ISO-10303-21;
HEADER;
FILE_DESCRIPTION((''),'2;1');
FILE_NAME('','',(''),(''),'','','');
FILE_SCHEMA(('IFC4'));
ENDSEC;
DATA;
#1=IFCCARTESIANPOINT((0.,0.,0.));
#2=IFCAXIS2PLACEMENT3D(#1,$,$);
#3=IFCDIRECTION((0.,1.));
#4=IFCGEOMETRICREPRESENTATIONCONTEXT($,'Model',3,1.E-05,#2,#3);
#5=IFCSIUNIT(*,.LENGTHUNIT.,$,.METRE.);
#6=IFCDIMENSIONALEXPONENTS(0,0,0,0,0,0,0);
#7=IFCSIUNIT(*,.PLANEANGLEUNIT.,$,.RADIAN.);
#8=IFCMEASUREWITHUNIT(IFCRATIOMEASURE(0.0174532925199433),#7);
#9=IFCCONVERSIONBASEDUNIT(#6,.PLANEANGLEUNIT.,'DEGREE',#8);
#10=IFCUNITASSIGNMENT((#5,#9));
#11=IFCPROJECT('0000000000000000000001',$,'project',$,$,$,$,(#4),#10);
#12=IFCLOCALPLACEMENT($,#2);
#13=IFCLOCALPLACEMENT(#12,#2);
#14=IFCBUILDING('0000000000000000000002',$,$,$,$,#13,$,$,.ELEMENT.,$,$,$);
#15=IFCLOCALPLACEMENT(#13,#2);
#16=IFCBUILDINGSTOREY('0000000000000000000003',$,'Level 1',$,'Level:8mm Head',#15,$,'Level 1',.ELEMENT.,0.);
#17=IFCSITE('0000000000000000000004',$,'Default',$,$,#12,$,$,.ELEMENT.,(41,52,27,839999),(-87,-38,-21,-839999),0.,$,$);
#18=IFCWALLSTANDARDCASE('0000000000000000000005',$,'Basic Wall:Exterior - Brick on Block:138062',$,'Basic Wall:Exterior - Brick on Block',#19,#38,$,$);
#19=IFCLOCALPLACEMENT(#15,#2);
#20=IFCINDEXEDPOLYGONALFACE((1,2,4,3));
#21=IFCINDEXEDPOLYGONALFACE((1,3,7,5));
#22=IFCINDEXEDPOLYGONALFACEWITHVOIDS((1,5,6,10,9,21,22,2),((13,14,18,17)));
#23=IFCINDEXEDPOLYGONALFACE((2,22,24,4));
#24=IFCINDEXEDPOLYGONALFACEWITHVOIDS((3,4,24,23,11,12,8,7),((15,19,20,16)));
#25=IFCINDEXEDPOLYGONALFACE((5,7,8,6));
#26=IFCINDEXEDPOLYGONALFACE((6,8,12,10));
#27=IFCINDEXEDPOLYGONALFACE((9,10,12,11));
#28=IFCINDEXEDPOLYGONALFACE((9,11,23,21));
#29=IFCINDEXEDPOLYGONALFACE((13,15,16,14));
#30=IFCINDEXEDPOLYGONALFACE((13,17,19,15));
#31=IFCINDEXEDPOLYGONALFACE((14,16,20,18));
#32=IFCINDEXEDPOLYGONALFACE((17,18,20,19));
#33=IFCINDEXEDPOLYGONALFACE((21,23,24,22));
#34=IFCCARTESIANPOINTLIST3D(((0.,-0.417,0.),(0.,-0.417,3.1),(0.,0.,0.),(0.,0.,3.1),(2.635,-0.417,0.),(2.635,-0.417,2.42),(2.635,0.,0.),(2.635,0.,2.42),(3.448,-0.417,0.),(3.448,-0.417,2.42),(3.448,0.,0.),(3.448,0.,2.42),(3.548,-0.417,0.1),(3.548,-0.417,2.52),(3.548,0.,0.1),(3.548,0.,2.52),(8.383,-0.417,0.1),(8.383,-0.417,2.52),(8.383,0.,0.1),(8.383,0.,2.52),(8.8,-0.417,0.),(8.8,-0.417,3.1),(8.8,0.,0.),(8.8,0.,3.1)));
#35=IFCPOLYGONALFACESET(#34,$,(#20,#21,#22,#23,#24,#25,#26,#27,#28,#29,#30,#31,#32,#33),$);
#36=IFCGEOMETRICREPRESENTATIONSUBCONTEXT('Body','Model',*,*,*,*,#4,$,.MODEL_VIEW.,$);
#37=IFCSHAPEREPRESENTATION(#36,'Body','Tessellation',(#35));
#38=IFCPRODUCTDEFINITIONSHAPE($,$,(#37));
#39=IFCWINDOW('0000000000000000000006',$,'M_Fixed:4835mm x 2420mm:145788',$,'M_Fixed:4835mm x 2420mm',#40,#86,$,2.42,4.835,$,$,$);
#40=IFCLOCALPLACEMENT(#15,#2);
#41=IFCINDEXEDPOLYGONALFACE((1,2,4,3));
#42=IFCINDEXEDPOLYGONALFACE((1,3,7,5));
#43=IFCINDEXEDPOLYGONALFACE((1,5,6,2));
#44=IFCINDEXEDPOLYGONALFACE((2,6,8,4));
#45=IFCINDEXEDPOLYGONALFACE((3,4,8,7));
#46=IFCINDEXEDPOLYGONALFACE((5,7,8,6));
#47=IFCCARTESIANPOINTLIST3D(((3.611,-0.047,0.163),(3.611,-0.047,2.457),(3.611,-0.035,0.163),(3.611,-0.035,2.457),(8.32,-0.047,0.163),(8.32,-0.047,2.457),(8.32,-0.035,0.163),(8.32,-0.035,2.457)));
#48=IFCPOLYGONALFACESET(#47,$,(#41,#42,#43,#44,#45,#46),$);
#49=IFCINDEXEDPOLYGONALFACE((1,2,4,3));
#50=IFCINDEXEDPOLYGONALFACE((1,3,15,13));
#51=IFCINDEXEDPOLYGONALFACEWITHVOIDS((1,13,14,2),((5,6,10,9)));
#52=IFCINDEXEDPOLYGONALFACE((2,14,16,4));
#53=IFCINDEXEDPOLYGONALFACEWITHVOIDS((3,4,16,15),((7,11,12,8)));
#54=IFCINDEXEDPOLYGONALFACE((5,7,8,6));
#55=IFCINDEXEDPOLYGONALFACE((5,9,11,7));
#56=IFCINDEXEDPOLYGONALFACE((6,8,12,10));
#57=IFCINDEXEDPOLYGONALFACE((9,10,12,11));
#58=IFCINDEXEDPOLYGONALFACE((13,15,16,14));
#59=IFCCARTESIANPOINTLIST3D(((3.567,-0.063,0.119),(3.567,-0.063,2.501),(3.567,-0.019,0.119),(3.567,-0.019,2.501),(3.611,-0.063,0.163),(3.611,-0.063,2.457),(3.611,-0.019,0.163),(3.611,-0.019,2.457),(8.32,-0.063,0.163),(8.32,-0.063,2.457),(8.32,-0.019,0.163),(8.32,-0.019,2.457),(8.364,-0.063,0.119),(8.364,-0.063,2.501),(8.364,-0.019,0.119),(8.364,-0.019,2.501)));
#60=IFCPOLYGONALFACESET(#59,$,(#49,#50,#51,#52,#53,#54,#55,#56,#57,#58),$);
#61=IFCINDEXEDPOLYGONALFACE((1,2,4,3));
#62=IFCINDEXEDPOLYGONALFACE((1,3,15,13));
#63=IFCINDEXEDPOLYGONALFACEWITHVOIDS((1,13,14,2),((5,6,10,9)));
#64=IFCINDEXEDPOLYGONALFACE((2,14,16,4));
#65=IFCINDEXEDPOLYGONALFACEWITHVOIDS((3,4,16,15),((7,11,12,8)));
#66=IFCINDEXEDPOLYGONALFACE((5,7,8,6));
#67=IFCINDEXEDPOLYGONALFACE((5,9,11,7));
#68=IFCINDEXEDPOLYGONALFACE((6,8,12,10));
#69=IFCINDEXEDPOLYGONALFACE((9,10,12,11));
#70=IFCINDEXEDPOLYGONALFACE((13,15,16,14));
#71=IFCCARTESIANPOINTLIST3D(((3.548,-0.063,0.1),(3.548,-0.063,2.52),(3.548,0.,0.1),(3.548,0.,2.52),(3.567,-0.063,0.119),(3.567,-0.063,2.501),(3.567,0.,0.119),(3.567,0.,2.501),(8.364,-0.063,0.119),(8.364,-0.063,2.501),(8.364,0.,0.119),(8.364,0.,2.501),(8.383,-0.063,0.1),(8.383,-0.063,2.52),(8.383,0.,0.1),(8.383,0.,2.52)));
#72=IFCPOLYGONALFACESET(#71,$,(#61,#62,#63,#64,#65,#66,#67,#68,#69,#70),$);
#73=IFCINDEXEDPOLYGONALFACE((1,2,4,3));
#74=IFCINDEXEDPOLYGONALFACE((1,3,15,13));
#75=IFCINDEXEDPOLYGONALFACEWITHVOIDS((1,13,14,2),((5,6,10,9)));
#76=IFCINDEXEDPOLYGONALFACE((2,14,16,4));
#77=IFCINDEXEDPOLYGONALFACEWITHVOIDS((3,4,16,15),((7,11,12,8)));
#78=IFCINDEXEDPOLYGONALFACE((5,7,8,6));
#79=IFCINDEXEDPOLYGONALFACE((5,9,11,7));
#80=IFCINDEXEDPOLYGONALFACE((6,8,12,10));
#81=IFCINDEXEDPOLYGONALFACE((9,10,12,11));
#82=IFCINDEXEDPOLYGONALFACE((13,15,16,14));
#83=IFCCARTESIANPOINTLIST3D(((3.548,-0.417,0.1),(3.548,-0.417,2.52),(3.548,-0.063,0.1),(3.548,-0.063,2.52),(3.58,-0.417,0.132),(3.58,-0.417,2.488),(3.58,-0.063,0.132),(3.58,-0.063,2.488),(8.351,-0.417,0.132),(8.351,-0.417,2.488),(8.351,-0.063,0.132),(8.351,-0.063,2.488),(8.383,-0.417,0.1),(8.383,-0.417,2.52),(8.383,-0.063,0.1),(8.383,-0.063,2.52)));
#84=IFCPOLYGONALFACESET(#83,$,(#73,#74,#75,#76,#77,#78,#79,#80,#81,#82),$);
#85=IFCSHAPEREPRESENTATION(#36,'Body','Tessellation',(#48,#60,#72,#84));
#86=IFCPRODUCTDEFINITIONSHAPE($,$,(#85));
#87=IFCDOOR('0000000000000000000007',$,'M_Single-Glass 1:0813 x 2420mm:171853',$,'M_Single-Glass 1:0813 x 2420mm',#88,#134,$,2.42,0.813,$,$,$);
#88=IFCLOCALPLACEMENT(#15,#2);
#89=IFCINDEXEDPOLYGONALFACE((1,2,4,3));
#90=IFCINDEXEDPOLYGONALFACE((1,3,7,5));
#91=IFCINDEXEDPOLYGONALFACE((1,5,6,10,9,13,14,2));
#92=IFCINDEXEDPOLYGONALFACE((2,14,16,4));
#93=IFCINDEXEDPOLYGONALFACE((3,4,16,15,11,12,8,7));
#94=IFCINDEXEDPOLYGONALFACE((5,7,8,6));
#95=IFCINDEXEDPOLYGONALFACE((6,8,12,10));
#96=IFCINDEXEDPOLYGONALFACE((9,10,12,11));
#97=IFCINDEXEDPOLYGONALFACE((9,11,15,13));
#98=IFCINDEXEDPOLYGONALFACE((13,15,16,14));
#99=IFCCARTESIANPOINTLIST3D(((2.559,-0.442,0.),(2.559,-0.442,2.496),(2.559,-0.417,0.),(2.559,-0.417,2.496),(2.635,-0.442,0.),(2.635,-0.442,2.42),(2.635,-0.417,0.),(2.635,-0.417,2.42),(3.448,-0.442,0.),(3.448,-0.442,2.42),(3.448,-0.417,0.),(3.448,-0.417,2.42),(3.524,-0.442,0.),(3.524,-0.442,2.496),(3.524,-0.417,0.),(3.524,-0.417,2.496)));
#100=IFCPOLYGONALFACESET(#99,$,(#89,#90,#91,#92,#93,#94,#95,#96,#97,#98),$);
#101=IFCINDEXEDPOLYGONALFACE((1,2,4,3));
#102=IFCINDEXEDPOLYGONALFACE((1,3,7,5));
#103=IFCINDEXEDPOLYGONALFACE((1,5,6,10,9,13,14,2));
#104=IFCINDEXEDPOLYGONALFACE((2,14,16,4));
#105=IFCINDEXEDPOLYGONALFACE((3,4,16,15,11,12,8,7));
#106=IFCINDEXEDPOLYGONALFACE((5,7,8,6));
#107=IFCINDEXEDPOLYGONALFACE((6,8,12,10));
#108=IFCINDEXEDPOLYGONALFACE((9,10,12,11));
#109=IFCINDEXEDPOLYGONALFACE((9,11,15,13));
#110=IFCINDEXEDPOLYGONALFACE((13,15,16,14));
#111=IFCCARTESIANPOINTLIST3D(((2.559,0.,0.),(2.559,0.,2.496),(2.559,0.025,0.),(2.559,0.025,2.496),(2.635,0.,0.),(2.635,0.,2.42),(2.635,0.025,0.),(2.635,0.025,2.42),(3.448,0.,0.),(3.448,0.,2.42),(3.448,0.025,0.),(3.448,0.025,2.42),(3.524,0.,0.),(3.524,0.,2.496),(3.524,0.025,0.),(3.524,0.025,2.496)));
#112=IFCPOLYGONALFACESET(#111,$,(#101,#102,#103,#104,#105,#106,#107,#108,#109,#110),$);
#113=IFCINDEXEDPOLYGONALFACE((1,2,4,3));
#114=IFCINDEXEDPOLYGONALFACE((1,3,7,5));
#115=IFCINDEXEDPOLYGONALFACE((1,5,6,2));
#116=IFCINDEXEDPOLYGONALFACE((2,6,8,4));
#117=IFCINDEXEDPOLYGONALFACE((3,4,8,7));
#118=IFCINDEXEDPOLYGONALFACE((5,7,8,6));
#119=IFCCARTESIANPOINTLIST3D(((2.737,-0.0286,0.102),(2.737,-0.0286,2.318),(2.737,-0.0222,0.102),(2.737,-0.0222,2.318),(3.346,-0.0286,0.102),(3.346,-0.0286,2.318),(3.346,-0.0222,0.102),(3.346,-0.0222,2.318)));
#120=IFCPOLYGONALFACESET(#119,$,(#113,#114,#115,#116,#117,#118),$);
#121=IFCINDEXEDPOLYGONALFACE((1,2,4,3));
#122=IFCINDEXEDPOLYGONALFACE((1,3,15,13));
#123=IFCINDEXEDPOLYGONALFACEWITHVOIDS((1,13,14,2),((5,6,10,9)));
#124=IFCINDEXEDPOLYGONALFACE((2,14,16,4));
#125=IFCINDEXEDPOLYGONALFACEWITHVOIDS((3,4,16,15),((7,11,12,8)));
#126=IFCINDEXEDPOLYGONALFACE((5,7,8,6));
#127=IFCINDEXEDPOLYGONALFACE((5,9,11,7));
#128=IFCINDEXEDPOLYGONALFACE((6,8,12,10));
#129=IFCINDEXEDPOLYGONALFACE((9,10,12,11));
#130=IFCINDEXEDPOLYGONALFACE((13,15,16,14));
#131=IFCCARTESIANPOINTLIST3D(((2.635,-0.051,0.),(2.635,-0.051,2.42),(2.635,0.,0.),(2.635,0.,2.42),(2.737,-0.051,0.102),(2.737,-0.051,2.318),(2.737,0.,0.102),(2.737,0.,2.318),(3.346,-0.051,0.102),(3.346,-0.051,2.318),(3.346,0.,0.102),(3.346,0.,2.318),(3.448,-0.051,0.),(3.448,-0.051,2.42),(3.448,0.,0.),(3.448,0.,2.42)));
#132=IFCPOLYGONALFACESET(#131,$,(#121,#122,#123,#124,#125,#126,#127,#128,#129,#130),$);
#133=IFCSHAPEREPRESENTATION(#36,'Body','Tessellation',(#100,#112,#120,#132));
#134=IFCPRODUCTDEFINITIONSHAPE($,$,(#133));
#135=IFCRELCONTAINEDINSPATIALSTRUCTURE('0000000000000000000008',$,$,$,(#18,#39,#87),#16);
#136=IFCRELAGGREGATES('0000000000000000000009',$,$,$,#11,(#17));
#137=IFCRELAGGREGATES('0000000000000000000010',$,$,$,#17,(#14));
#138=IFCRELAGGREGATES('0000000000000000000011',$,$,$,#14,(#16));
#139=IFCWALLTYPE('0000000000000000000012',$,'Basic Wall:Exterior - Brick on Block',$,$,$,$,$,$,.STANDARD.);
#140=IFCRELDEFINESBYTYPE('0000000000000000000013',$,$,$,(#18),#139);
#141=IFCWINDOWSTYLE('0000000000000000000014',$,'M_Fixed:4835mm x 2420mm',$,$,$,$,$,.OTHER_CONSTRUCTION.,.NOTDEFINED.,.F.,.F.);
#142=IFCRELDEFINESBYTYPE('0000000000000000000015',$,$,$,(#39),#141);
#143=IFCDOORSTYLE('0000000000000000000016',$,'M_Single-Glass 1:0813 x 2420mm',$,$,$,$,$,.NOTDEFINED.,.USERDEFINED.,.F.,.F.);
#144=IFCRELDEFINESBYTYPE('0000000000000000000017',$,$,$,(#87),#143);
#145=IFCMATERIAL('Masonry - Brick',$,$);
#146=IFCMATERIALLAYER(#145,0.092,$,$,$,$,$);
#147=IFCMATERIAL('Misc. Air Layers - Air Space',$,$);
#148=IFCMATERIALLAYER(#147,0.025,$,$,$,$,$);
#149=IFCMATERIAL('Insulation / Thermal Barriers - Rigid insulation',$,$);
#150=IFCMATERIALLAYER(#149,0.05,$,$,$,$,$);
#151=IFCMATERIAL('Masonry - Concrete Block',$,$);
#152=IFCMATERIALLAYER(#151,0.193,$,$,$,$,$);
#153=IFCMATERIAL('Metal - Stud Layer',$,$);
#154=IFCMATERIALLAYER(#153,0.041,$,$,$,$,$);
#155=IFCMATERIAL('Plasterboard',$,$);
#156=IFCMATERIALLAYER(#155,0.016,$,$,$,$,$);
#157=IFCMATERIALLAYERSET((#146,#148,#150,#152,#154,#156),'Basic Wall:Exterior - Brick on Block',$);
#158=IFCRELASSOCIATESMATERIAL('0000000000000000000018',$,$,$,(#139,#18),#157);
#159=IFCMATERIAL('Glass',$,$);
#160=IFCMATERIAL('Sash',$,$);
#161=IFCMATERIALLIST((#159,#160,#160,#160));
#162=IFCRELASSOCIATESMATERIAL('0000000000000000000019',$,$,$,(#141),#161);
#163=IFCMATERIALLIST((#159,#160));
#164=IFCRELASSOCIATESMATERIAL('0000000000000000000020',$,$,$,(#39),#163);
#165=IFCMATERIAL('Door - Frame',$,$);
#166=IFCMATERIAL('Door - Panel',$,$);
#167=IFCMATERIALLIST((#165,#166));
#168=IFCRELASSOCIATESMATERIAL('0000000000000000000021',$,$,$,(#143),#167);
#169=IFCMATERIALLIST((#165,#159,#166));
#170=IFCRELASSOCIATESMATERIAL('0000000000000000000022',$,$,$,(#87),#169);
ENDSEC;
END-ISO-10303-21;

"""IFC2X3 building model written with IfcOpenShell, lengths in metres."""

from ifc_helpers import new_model, entity, si_unit, converted_unit, direction, frame, frame_2d, origin, origin_2d_with_axis, place, context, subcontext, project, spatial, polyline, rectangle, outline, extrude, source, transform, mapped, material, material_list, layer, layer_set, layer_usage, type_object, type_shapes, element, fill, save


model = new_model("IFC2X3")

# Units and contexts
model_context = context("Model", 3, precision=1e-05, world=origin(), true_north=direction((0.0, 1.0)))
body_context = subcontext(model_context, "Body", "Model", "MODEL_VIEW")
ifc_project = project(units=[si_unit("LENGTHUNIT", "METRE"), converted_unit("PLANEANGLEUNIT", "DEGREE", entity("IfcRatioMeasure", 0.0174532925199433), si_unit("PLANEANGLEUNIT", "RADIAN"), dimensions=[0, 0, 0, 0, 0, 0, 0])], contexts=[model_context])

# Site, building, storey
site_placement = place(None, origin())
site = spatial("IfcSite", under=ifc_project, at=site_placement, Name="Default", CompositionType="ELEMENT", RefLatitude=(41, 52, 27, 839999), RefLongitude=(-87, -38, -21, -839999), RefElevation=0.0)
building_placement = place(site_placement, origin())
building = spatial("IfcBuilding", under=site, at=building_placement, CompositionType="ELEMENT")
storey_placement = place(building_placement, origin())
storey = spatial("IfcBuildingStorey", under=building, at=storey_placement, Name="Level 1", ObjectType="Level:8mm Head", LongName="Level 1", CompositionType="ELEMENT", Elevation=0.0)

# Wall, openings, window, door
ifc_material_1 = material(Name="Masonry - Brick")
ifc_layer_1 = layer(ifc_material_1, 0.092)
ifc_material_2 = material(Name="Misc. Air Layers - Air Space")
ifc_layer_2 = layer(ifc_material_2, 0.025)
ifc_material_3 = material(Name="Insulation / Thermal Barriers - Rigid insulation")
ifc_layer_3 = layer(ifc_material_3, 0.05)
ifc_material_4 = material(Name="Masonry - Concrete Block")
ifc_layer_4 = layer(ifc_material_4, 0.193)
ifc_material_5 = material(Name="Metal - Stud Layer")
ifc_layer_5 = layer(ifc_material_5, 0.041)
ifc_material_6 = material(Name="Plasterboard")
ifc_layer_6 = layer(ifc_material_6, 0.016)
ifc_layer_set_1 = layer_set([ifc_layer_1, ifc_layer_2, ifc_layer_3, ifc_layer_4, ifc_layer_5, ifc_layer_6], Name="Basic Wall:Exterior - Brick on Block")
ifc_layer_usage_1 = layer_usage(ifc_layer_set_1, "AXIS2", "NEGATIVE", 0.2085)
wall_type_1 = type_object("IfcWallType", Name="Basic Wall:Exterior - Brick on Block", PredefinedType="STANDARD", material=ifc_layer_set_1)
wall_1_placement = place(storey_placement, frame((0.0, -0.2085, 0.0)))
wall_1 = element("IfcWallStandardCase", 1, at=wall_1_placement, inside=storey, type_object=wall_type_1, material=ifc_layer_usage_1, Name="Basic Wall:Exterior - Brick on Block:138062", ObjectType="Basic Wall:Exterior - Brick on Block", context=body_context, shape_type="SweptSolid", body=[
    extrude(rectangle(XDim=8.8, YDim=0.417, at=frame_2d((4.4, 0.0), x_axis=(-1.0, 0.0))), origin(), (0.0, 0.0, 1.0), 3.1),
])
opening_1_placement = place(wall_1_placement, frame((2.635, -0.2085, 0.0)))
opening_1 = element("IfcOpeningElement", 2, at=opening_1_placement, cuts=wall_1, ObjectType="Opening", context=body_context, shape_type="SweptSolid", body=[
    extrude(rectangle(XDim=0.813, YDim=2.42, at=frame_2d((1.21, 0.4065), x_axis=(0.0, -1.0))), frame((0.0, 0.0, 0.0), z_axis=(0.0, 1.0, 0.0), x_axis=(0.0, 0.0, 1.0)), (0.0, 0.0, 1.0), 0.417),
])
opening_2_placement = place(wall_1_placement, frame((3.548, -0.2085, 0.1)))
opening_2 = element("IfcOpeningElement", 3, at=opening_2_placement, cuts=wall_1, ObjectType="Opening", context=body_context, shape_type="SweptSolid", body=[
    extrude(rectangle(XDim=2.42, YDim=4.835, at=frame_2d((1.21, 2.4175), x_axis=(1.0, 0.0))), frame((0.0, 0.0, 0.0), z_axis=(0.0, 1.0, 0.0), x_axis=(0.0, 0.0, 1.0)), (0.0, 0.0, 1.0), 0.417),
])
ifc_material_7 = material(Name="Glass")
ifc_material_8 = material(Name="Sash")
ifc_material_list_1 = material_list([ifc_material_7, ifc_material_8])
ifc_material_list_2 = material_list([ifc_material_7, ifc_material_8, ifc_material_8, ifc_material_8])
window_style_1 = type_object("IfcWindowStyle", Name="M_Fixed:4835mm x 2420mm", ConstructionType="OTHER_CONSTRUCTION", OperationType="NOTDEFINED", ParameterTakesPrecedence=False, Sizeable=False, material=ifc_material_list_2)
shared_shape_1 = source(origin(), body_context, "Body", "SweptSolid", [
    extrude(rectangle(XDim=0.012, YDim=4.709, at=origin_2d_with_axis()), frame((2.4175, 0.376, 0.063), z_axis=(0.0, 0.0, 1.0), x_axis=(0.0, -1.0, 0.0)), (0.0, 0.0, 1.0), 2.294),
    extrude(outline(polyline([(-2.3985, -1.191), (2.3985, -1.191), (2.3985, 1.191), (-2.3985, 1.191), (-2.3985, -1.191)]), holes=[polyline([(-2.3545, -1.147), (-2.3545, 1.147), (2.3545, 1.147), (2.3545, -1.147), (-2.3545, -1.147)])]), frame((2.4175, 0.354, 1.21), z_axis=(0.0, 1.0, 0.0), x_axis=(1.0, 0.0, 0.0)), (0.0, 0.0, 1.0), 0.044),
    extrude(outline(polyline([(-2.4175, -1.21), (2.4175, -1.21), (2.4175, 1.21), (-2.4175, 1.21), (-2.4175, -1.21)]), holes=[polyline([(-2.3985, -1.191), (-2.3985, 1.191), (2.3985, 1.191), (2.3985, -1.191), (-2.3985, -1.191)])]), frame((2.4175, 0.354, 1.21), z_axis=(0.0, 1.0, 0.0), x_axis=(1.0, 0.0, 0.0)), (0.0, 0.0, 1.0), 0.063),
    extrude(outline(polyline([(-2.4175, -1.21), (2.4175, -1.21), (2.4175, 1.21), (-2.4175, 1.21), (-2.4175, -1.21)]), holes=[polyline([(-2.3855, -1.178), (-2.3855, 1.178), (2.3855, 1.178), (2.3855, -1.178), (-2.3855, -1.178)])]), frame((2.4175, 0.0, 1.21), z_axis=(0.0, 1.0, 0.0), x_axis=(1.0, 0.0, 0.0)), (0.0, 0.0, 1.0), 0.354),
])
type_shapes(window_style_1, [shared_shape_1])
window_1_placement = place(opening_2_placement, origin())
window_1 = element("IfcWindow", 4, at=window_1_placement, inside=storey, type_object=window_style_1, material=ifc_material_list_1, Name="M_Fixed:4835mm x 2420mm:145788", ObjectType="M_Fixed:4835mm x 2420mm", OverallHeight=2.42, OverallWidth=4.835, context=body_context, shape_type="MappedRepresentation", body=[
    mapped(shared_shape_1, transform((0.0, 0.0, 0.0), scale=1.0)),
])
fill(opening_2, window_1)
ifc_material_9 = material(Name="Door - Frame")
ifc_material_10 = material(Name="Door - Panel")
ifc_material_list_3 = material_list([ifc_material_9, ifc_material_7, ifc_material_10])
ifc_material_list_4 = material_list([ifc_material_9, ifc_material_10])
door_style_1 = type_object("IfcDoorStyle", Name="M_Single-Glass 1:0813 x 2420mm", ConstructionType="USERDEFINED", OperationType="NOTDEFINED", ParameterTakesPrecedence=False, Sizeable=False, material=ifc_material_list_4)
shared_shape_2 = source(origin(), body_context, "Body", "SweptSolid", [
    extrude(outline(polyline([(-0.4065, -1.191), (-0.4065, 1.229), (-0.4825, 1.229), (-0.4825, -1.267), (0.4825, -1.267), (0.4825, 1.229), (0.4065, 1.229), (0.4065, -1.191), (-0.4065, -1.191)])), frame((0.4065, 0.0, 1.229), z_axis=(0.0, 1.0, 0.0), x_axis=(1.0, 0.0, 0.0)), (0.0, 0.0, -1.0), 0.025),
    extrude(outline(polyline([(-0.4065, -1.191), (-0.4065, 1.229), (-0.4825, 1.229), (-0.4825, -1.267), (0.4825, -1.267), (0.4825, 1.229), (0.4065, 1.229), (0.4065, -1.191), (-0.4065, -1.191)])), frame((0.4065, 0.442, 1.229), z_axis=(0.0, 1.0, 0.0), x_axis=(1.0, 0.0, 0.0)), (0.0, 0.0, -1.0), 0.025),
    extrude(rectangle(XDim=0.609, YDim=0.0064, at=frame_2d((0.0, 0.0), x_axis=(1.0, 0.0))), frame((0.4065, 0.3916, 0.102)), (0.0, 0.0, 1.0), 2.216),
    extrude(outline(polyline([(-1.21, -0.4065), (1.21, -0.4065), (1.21, 0.4065), (-1.21, 0.4065), (-1.21, -0.4065)]), holes=[polyline([(-1.108, 0.3045), (1.108, 0.3045), (1.108, -0.3045), (-1.108, -0.3045), (-1.108, 0.3045)])]), frame((0.4065, 0.417, 1.21), z_axis=(0.0, -1.0, 0.0), x_axis=(0.0, 0.0, -1.0)), (0.0, 0.0, 1.0), 0.051),
])
type_shapes(door_style_1, [shared_shape_2])
door_1_placement = place(opening_1_placement, origin())
door_1 = element("IfcDoor", 5, at=door_1_placement, inside=storey, type_object=door_style_1, material=ifc_material_list_3, Name="M_Single-Glass 1:0813 x 2420mm:171853", ObjectType="M_Single-Glass 1:0813 x 2420mm", OverallHeight=2.42, OverallWidth=0.813, context=body_context, shape_type="MappedRepresentation", body=[
    mapped(shared_shape_2, transform((0.0, 0.0, 0.0), scale=1.0)),
])
fill(opening_1, door_1)

save(model, "model.ifc")
